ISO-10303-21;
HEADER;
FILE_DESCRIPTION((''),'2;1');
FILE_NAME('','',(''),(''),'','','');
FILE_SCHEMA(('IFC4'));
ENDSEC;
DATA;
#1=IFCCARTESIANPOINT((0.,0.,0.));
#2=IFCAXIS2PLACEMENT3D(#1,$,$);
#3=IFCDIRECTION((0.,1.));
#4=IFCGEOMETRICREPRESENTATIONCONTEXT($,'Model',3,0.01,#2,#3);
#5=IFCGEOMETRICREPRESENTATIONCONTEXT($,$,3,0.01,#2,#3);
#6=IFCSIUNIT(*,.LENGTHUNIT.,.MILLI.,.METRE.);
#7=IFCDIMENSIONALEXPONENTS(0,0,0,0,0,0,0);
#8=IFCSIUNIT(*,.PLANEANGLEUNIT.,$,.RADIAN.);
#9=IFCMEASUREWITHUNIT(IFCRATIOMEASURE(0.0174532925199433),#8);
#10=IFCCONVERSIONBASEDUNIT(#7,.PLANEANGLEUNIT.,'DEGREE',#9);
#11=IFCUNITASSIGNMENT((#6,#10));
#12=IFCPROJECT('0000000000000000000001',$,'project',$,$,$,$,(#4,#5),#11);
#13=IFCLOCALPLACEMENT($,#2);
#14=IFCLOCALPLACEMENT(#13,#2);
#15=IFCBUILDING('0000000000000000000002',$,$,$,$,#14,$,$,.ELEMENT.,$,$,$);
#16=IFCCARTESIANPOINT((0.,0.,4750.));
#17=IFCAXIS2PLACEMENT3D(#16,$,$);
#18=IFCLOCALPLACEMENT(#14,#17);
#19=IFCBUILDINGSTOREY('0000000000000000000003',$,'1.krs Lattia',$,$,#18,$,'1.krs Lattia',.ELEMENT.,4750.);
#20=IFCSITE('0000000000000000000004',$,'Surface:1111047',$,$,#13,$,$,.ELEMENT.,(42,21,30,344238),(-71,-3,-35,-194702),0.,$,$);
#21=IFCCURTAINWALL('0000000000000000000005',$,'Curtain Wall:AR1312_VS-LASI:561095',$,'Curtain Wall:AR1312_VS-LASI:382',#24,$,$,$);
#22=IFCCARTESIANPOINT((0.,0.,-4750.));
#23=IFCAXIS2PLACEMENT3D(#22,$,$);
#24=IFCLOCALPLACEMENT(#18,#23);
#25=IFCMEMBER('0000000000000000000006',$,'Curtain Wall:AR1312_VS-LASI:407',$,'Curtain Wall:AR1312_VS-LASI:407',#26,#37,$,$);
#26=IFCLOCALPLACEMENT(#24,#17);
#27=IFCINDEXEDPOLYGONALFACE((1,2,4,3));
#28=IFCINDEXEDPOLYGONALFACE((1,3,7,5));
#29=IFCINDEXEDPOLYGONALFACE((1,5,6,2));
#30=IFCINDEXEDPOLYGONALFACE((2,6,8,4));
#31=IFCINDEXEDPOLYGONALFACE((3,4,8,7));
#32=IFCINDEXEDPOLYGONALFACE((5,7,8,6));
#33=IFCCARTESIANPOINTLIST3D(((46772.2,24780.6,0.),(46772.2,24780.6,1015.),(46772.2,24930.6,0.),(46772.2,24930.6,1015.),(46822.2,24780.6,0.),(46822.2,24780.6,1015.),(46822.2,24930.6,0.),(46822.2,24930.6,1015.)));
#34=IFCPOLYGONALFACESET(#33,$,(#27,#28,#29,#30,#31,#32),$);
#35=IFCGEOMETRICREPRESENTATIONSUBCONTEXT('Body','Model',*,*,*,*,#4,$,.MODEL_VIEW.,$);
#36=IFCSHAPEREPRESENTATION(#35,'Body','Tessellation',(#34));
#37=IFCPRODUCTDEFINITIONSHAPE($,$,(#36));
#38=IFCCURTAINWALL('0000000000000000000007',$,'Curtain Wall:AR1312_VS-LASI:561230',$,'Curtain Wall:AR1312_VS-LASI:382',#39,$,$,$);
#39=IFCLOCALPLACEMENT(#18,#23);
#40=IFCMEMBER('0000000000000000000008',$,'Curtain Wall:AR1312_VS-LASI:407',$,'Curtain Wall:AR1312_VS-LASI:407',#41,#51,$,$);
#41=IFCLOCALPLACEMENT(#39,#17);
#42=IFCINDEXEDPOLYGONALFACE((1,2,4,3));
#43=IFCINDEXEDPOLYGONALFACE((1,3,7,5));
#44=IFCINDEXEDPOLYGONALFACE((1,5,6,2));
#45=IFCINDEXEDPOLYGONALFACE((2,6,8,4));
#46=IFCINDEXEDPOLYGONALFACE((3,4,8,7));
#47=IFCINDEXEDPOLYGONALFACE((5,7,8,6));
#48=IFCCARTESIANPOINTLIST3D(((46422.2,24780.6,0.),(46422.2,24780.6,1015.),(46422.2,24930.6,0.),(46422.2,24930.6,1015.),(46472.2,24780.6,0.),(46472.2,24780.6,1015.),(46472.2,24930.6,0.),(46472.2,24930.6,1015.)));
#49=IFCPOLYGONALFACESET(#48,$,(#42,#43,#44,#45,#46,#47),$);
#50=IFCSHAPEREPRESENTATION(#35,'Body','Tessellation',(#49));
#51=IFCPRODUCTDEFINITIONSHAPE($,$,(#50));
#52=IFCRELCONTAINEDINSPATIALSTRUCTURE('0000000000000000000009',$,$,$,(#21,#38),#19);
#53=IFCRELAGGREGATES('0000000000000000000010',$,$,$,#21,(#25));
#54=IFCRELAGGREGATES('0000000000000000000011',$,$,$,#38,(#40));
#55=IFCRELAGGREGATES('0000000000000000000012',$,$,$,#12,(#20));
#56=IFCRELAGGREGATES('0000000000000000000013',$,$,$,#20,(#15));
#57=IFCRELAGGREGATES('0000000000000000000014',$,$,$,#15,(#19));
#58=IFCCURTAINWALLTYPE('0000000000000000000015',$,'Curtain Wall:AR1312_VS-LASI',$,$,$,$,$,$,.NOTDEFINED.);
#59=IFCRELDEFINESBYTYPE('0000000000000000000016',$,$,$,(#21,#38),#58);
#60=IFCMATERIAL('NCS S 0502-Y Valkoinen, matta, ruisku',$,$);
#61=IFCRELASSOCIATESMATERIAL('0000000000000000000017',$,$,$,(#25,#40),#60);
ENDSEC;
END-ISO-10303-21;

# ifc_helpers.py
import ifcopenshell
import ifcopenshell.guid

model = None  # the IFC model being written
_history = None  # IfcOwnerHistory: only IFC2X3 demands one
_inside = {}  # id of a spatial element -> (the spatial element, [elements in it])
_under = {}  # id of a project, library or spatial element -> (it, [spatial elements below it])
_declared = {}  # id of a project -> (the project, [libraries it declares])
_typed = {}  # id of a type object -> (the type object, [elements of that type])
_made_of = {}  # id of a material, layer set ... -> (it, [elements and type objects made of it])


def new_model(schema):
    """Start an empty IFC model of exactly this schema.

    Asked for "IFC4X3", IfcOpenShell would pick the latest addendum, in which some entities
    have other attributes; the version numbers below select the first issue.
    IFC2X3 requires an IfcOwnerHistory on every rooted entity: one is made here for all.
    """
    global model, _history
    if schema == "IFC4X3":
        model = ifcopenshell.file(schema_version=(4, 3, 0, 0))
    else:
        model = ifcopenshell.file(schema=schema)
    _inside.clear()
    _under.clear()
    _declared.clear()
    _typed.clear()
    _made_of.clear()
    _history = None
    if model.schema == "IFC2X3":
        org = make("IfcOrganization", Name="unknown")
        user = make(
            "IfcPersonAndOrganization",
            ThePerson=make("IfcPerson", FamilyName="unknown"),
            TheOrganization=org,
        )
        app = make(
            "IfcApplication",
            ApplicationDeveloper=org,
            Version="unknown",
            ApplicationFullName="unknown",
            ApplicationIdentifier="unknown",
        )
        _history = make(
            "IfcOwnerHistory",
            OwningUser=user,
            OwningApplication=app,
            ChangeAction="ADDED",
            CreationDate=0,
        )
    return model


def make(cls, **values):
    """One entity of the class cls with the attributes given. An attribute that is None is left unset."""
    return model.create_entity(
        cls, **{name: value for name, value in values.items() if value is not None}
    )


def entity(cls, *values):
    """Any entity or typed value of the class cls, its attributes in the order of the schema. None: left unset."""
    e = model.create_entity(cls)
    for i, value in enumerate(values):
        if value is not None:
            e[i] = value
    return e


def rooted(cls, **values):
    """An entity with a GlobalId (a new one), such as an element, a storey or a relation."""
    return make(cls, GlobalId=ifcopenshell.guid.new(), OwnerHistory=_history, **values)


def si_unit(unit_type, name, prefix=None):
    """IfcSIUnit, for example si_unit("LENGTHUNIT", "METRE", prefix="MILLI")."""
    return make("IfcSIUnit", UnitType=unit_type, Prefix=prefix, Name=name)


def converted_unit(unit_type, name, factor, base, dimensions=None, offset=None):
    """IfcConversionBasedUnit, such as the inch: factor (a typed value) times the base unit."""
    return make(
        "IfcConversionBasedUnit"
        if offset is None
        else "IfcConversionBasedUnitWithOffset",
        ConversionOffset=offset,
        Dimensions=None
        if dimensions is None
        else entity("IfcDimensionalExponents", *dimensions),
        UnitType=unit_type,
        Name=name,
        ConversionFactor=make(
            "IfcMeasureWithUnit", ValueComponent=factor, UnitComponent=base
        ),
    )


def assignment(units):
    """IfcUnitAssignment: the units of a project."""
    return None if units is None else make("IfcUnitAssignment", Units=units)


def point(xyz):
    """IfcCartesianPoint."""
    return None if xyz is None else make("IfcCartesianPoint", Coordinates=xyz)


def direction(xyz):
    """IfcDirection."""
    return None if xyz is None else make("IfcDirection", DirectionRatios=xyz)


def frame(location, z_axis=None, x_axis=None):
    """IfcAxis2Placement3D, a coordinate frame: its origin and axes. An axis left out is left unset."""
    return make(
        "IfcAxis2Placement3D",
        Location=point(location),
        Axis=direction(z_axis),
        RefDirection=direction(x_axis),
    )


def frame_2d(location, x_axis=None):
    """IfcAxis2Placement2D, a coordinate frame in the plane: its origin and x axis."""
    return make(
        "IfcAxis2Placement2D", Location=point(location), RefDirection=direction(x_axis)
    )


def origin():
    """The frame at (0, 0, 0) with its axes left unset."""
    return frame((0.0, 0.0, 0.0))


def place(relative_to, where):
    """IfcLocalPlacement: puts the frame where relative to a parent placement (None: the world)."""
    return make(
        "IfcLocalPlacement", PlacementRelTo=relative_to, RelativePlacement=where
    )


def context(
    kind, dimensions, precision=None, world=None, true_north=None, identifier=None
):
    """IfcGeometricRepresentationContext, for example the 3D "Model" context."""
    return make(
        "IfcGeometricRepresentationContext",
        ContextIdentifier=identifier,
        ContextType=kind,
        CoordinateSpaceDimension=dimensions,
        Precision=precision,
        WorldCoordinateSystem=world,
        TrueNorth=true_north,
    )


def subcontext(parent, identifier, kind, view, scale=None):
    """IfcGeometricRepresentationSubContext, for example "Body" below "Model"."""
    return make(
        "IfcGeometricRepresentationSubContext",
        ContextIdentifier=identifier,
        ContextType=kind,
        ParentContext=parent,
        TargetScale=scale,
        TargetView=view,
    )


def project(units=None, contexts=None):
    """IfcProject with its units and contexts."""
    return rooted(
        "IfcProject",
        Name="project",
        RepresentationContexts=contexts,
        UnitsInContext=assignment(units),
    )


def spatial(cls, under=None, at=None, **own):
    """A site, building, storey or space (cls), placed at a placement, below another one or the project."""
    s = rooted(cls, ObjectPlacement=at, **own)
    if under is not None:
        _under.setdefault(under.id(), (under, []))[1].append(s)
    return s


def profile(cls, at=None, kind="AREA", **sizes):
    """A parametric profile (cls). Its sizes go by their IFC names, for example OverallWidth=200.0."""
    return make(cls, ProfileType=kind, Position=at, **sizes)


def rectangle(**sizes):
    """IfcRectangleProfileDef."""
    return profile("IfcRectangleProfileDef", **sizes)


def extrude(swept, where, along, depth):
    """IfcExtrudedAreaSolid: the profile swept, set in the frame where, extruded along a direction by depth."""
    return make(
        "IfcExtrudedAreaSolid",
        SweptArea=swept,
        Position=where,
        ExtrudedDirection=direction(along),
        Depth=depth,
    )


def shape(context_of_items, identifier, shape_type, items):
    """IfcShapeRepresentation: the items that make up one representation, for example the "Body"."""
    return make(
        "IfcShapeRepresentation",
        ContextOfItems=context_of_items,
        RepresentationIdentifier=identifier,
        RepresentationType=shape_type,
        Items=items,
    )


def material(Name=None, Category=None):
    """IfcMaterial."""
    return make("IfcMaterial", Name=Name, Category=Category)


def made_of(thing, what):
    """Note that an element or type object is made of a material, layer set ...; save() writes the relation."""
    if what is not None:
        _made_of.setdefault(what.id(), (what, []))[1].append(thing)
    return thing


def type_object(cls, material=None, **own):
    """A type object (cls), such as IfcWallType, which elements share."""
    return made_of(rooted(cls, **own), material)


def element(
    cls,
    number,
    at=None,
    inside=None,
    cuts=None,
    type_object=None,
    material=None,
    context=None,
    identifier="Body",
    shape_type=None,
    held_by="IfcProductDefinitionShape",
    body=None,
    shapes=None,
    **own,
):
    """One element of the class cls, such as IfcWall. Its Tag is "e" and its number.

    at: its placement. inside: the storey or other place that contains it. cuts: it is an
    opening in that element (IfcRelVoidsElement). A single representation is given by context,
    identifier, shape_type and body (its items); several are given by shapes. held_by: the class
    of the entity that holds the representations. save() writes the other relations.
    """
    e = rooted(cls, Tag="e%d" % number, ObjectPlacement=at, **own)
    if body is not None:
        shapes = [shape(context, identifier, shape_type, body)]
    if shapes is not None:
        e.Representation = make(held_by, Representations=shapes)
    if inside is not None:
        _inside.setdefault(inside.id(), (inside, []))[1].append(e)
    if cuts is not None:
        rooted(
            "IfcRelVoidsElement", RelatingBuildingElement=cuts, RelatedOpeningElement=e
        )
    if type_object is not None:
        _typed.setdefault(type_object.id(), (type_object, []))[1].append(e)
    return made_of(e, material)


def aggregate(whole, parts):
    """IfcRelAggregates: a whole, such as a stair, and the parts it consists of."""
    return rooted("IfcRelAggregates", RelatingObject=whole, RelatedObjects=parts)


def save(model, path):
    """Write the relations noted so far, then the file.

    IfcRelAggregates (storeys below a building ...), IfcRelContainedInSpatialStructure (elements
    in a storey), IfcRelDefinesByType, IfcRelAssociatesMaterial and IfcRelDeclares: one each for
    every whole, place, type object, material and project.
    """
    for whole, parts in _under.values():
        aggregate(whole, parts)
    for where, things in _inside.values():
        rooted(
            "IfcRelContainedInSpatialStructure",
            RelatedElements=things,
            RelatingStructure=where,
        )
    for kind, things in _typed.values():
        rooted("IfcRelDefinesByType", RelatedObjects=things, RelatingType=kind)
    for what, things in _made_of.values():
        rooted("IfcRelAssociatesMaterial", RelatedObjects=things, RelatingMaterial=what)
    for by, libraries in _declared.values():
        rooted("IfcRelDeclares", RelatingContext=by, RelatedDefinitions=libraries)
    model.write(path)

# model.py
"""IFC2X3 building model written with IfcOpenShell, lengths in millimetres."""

from ifc_helpers import new_model, entity, si_unit, converted_unit, direction, frame, frame_2d, origin, place, context, subcontext, project, spatial, rectangle, extrude, material, type_object, element, aggregate, save


model = new_model("IFC2X3")

# Units and contexts
model_context = context("Model", 3, precision=0.01, world=origin(), true_north=direction((0.0, 1.0)))
context_of_model = context(None, 3, precision=0.01, world=origin(), true_north=direction((0.0, 1.0)))
body_context = subcontext(model_context, "Body", "Model", "MODEL_VIEW")
ifc_project = project(units=[si_unit("LENGTHUNIT", "METRE", prefix="MILLI"), converted_unit("PLANEANGLEUNIT", "DEGREE", entity("IfcRatioMeasure", 0.0174532925199433), si_unit("PLANEANGLEUNIT", "RADIAN"), dimensions=[0, 0, 0, 0, 0, 0, 0])], contexts=[model_context, context_of_model])

# Site, building, storey
site_placement = place(None, origin())
site = spatial("IfcSite", under=ifc_project, at=site_placement, Name="Surface:1111047", CompositionType="ELEMENT", RefLatitude=(42, 21, 30, 344238), RefLongitude=(-71, -3, -35, -194702), RefElevation=0.0)
building_placement = place(site_placement, origin())
building = spatial("IfcBuilding", under=site, at=building_placement, CompositionType="ELEMENT")
storey_placement = place(building_placement, frame((0.0, 0.0, 4750.0)))
storey = spatial("IfcBuildingStorey", under=building, at=storey_placement, Name="1.krs Lattia", LongName="1.krs Lattia", CompositionType="ELEMENT", Elevation=4750.0)

# Curtain walls, members
curtain_wall_type = type_object("IfcCurtainWallType", Name="Curtain Wall:AR1312_VS-LASI", PredefinedType="NOTDEFINED")
curtain_wall_1_placement = place(storey_placement, frame((0.0, 0.0, -4750.0)))
curtain_wall_1 = element("IfcCurtainWall", 1, at=curtain_wall_1_placement, inside=storey, type_object=curtain_wall_type, Name="Curtain Wall:AR1312_VS-LASI:561095", ObjectType="Curtain Wall:AR1312_VS-LASI:382")
ifc_material = material(Name="NCS S 0502-Y Valkoinen, matta, ruisku")
member_1_placement = place(curtain_wall_1_placement, frame((0.0, 0.0, 4750.0)))
member_1 = element("IfcMember", 2, at=member_1_placement, material=ifc_material, Name="Curtain Wall:AR1312_VS-LASI:407", ObjectType="Curtain Wall:AR1312_VS-LASI:407", context=body_context, shape_type="SweptSolid", body=[
    extrude(rectangle(XDim=50.0, YDim=150.0, at=frame_2d((0.0, 0.0), x_axis=(1.0, 0.0))), frame((46797.2, 24855.6, 0.0), z_axis=(0.0, 0.0, 1.0), x_axis=(-1.0, 0.0, 0.0)), (0.0, 0.0, 1.0), 1015.0),
])
aggregate(curtain_wall_1, [member_1])
curtain_wall_2_placement = place(storey_placement, frame((0.0, 0.0, -4750.0)))
curtain_wall_2 = element("IfcCurtainWall", 3, at=curtain_wall_2_placement, inside=storey, type_object=curtain_wall_type, Name="Curtain Wall:AR1312_VS-LASI:561230", ObjectType="Curtain Wall:AR1312_VS-LASI:382")
member_2_placement = place(curtain_wall_2_placement, frame((0.0, 0.0, 4750.0)))
member_2 = element("IfcMember", 4, at=member_2_placement, material=ifc_material, Name="Curtain Wall:AR1312_VS-LASI:407", ObjectType="Curtain Wall:AR1312_VS-LASI:407", context=body_context, shape_type="SweptSolid", body=[
    extrude(rectangle(XDim=50.0, YDim=150.0, at=frame_2d((0.0, 0.0), x_axis=(1.0, 0.0))), frame((46447.2, 24855.6, 0.0), z_axis=(0.0, 0.0, 1.0), x_axis=(-1.0, 0.0, 0.0)), (0.0, 0.0, 1.0), 1015.0),
])
aggregate(curtain_wall_2, [member_2])

save(model, "model.ifc")
